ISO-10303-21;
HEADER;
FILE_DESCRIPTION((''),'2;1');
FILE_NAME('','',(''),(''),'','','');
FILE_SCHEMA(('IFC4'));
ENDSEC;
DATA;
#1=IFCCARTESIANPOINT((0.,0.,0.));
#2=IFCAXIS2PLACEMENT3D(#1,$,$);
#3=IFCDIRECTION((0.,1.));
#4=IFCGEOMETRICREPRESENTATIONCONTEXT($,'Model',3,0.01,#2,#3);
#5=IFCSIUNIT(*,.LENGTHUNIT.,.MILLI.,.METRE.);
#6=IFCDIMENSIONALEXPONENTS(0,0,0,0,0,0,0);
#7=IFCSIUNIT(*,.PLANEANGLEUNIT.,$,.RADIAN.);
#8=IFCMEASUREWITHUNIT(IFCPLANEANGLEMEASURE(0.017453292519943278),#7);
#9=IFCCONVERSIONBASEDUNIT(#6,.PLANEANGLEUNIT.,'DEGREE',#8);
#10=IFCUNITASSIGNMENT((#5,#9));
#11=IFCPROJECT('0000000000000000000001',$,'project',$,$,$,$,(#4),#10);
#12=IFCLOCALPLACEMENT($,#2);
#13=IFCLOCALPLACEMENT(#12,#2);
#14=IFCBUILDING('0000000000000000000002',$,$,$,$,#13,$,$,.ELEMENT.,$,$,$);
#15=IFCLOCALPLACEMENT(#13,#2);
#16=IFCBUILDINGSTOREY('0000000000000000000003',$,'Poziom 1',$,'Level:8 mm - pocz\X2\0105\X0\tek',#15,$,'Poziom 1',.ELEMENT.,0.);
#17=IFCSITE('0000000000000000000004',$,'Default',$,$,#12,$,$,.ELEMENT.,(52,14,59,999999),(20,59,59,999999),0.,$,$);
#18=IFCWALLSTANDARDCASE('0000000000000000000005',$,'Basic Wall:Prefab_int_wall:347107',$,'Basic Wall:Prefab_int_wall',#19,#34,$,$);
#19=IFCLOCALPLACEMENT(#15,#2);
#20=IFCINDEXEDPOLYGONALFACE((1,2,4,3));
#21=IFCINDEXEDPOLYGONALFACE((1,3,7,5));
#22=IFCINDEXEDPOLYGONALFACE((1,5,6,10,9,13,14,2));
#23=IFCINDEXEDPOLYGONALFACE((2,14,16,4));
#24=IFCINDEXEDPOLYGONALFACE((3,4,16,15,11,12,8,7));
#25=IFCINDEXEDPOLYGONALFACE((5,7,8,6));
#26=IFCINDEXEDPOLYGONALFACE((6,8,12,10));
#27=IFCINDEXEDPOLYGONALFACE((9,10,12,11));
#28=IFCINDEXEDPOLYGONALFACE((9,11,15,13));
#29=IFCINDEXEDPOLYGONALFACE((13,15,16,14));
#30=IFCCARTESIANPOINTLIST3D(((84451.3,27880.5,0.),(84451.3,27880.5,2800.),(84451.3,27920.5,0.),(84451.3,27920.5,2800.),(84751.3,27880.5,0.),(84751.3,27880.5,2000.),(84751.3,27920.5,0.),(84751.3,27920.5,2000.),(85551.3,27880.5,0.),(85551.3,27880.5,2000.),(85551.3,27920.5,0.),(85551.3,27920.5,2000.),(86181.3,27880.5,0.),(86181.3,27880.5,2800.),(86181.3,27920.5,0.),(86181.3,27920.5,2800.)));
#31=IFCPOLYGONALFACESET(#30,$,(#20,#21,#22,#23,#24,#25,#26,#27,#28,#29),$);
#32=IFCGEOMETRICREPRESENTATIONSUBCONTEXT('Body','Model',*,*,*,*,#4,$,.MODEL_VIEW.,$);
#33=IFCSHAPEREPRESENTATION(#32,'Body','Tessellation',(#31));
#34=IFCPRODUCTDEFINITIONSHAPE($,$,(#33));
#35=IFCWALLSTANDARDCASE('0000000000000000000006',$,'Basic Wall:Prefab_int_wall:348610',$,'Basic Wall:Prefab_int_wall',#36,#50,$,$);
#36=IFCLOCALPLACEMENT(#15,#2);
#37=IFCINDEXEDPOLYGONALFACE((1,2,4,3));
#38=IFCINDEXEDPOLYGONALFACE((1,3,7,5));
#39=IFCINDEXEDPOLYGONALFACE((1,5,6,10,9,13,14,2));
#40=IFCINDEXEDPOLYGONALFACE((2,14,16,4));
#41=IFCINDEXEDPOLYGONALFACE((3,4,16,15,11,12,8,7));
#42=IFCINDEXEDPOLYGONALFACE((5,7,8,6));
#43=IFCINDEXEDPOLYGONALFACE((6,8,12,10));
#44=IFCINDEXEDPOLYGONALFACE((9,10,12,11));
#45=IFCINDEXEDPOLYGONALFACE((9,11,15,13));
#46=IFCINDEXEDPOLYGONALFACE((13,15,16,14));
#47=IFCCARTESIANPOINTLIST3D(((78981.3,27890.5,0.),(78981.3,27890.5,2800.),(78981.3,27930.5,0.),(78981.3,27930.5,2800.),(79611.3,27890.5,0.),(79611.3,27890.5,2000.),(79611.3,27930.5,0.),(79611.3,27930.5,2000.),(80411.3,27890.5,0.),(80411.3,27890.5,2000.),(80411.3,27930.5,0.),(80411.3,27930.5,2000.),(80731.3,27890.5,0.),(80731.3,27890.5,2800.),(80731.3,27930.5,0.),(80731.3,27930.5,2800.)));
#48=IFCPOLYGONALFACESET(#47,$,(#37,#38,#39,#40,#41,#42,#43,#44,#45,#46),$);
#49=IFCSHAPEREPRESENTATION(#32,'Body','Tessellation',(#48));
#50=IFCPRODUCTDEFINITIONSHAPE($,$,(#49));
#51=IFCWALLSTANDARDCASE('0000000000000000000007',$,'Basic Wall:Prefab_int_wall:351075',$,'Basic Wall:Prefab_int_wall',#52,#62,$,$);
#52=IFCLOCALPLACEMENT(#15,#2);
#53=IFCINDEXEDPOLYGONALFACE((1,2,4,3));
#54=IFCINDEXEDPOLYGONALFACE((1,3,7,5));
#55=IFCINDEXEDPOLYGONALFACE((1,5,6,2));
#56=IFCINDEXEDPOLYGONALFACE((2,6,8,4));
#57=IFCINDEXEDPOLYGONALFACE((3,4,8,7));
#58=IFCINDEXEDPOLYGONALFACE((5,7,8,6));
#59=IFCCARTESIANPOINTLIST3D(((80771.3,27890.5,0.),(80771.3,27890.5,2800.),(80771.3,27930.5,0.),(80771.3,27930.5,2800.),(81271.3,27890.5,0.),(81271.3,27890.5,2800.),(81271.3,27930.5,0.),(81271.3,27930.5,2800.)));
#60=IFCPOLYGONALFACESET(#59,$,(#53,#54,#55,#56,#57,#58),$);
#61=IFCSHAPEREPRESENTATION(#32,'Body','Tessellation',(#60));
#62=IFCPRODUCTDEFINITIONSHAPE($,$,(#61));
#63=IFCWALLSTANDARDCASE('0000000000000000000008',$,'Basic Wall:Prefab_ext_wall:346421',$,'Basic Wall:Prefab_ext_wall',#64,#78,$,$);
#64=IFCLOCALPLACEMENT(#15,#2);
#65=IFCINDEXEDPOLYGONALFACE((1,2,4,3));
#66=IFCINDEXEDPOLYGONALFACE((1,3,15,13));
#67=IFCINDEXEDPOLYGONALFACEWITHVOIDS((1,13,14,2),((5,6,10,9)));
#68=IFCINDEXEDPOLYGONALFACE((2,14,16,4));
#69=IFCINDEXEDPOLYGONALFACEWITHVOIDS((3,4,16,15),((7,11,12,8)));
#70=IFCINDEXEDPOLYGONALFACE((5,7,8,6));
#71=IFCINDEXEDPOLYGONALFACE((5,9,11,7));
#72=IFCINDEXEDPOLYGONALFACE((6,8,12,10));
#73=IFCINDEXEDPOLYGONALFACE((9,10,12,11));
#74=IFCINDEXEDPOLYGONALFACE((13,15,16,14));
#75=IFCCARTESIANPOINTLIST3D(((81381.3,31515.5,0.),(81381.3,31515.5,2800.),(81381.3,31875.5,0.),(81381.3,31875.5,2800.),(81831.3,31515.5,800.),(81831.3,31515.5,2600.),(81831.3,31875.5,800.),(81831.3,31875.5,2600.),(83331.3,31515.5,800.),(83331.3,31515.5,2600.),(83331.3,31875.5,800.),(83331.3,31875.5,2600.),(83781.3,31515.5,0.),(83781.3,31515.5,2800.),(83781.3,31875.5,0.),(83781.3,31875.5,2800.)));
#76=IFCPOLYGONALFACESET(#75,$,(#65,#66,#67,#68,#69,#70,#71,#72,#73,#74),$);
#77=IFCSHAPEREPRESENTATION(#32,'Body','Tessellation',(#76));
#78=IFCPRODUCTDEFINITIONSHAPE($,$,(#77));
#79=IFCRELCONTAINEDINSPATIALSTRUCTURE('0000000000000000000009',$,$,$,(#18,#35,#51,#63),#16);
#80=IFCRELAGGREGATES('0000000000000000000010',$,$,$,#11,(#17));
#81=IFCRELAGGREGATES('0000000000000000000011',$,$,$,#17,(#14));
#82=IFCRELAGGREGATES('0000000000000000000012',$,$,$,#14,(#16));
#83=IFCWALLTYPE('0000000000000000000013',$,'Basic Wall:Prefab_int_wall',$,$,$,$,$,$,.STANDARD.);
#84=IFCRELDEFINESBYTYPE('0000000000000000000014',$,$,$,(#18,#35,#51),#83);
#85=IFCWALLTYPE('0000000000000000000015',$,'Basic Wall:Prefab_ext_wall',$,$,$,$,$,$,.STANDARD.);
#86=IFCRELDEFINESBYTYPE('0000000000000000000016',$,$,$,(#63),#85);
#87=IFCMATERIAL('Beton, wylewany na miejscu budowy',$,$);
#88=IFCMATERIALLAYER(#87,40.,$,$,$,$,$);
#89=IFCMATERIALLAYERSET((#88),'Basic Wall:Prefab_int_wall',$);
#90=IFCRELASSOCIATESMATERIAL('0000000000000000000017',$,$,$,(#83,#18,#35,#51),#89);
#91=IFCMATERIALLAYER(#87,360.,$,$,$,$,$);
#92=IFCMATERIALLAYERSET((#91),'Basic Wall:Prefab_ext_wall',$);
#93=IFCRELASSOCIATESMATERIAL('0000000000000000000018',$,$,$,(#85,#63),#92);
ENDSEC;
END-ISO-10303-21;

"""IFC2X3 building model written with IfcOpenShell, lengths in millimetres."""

from ifc_helpers import new_model, entity, si_unit, converted_unit, direction, frame, frame_2d, origin, origin_2d_with_axis, place, context, subcontext, project, spatial, rectangle, extrude, material, layer, layer_set, layer_usage, type_object, element, save


model = new_model("IFC2X3")

# Units and contexts
model_context = context("Model", 3, precision=0.01, world=origin(), true_north=direction((0.0, 1.0)))
body_context = subcontext(model_context, "Body", "Model", "MODEL_VIEW")
ifc_project = project(units=[si_unit("LENGTHUNIT", "METRE", prefix="MILLI"), converted_unit("PLANEANGLEUNIT", "DEGREE", entity("IfcPlaneAngleMeasure", 0.017453292519943278), si_unit("PLANEANGLEUNIT", "RADIAN"), dimensions=[0, 0, 0, 0, 0, 0, 0])], contexts=[model_context])

# Site, building, storey
site_placement = place(None, origin())
site = spatial("IfcSite", under=ifc_project, at=site_placement, Name="Default", CompositionType="ELEMENT", RefLatitude=(52, 14, 59, 999999), RefLongitude=(20, 59, 59, 999999), RefElevation=0.0)
building_placement = place(site_placement, origin())
building = spatial("IfcBuilding", under=site, at=building_placement, CompositionType="ELEMENT")
storey_placement = place(building_placement, origin())
storey = spatial("IfcBuildingStorey", under=building, at=storey_placement, Name="Poziom 1", ObjectType="Level:8 mm - początek", LongName="Poziom 1", CompositionType="ELEMENT", Elevation=0.0)

# Shared definitions
ifc_material = material(Name="Beton, wylewany na miejscu budowy")
ifc_layer_1 = layer(ifc_material, 40.0)
ifc_layer_set_1 = layer_set([ifc_layer_1], Name="Basic Wall:Prefab_int_wall")
wall_type_1 = type_object("IfcWallType", Name="Basic Wall:Prefab_int_wall", PredefinedType="STANDARD", material=ifc_layer_set_1)

# Walls, openings
ifc_layer_usage_1 = layer_usage(ifc_layer_set_1, "AXIS2", "NEGATIVE", 20.0)
wall_1_placement = place(storey_placement, frame((84451.3, 27900.5, 0.0)))
wall_1 = element("IfcWallStandardCase", 1, at=wall_1_placement, inside=storey, type_object=wall_type_1, material=ifc_layer_usage_1, Name="Basic Wall:Prefab_int_wall:347107", ObjectType="Basic Wall:Prefab_int_wall", context=body_context, shape_type="SweptSolid", body=[
    extrude(rectangle(XDim=1730.0, YDim=40.0, at=frame_2d((865.0, 0.0), x_axis=(-1.0, 0.0))), origin(), (0.0, 0.0, 1.0), 2800.0),
])
opening_1_placement = place(wall_1_placement, origin())
element("IfcOpeningElement", 2, at=opening_1_placement, cuts=wall_1, ObjectType="Opening", context=body_context, shape_type="SweptSolid", body=[
    extrude(rectangle(XDim=2000.0, YDim=800.0, at=frame_2d((0.0, 0.0), x_axis=(0.0, 1.0))), frame((700.0, 20.0, 1000.0), z_axis=(0.0, -1.0, 0.0), x_axis=(1.0, 0.0, 0.0)), (0.0, 0.0, 1.0), 40.0),
])
ifc_layer_usage_2 = layer_usage(ifc_layer_set_1, "AXIS2", "NEGATIVE", 20.0)
wall_2_placement = place(storey_placement, frame((78981.3, 27910.5, 0.0)))
wall_2 = element("IfcWallStandardCase", 3, at=wall_2_placement, inside=storey, type_object=wall_type_1, material=ifc_layer_usage_2, Name="Basic Wall:Prefab_int_wall:348610", ObjectType="Basic Wall:Prefab_int_wall", context=body_context, shape_type="SweptSolid", body=[
    extrude(rectangle(XDim=1750.0, YDim=40.0, at=frame_2d((875.0, 0.0), x_axis=(-1.0, 0.0))), origin(), (0.0, 0.0, 1.0), 2800.0),
])
opening_2_placement = place(wall_2_placement, origin())
element("IfcOpeningElement", 4, at=opening_2_placement, cuts=wall_2, ObjectType="Opening", context=body_context, shape_type="SweptSolid", body=[
    extrude(rectangle(XDim=2000.0, YDim=800.0, at=frame_2d((0.0, 0.0), x_axis=(0.0, 1.0))), frame((1030.0, 20.0, 1000.0), z_axis=(0.0, -1.0, 0.0), x_axis=(1.0, 0.0, 0.0)), (0.0, 0.0, 1.0), 40.0),
])

# Wall
ifc_layer_usage_3 = layer_usage(ifc_layer_set_1, "AXIS2", "NEGATIVE", 20.0)
wall_3_placement = place(storey_placement, frame((80771.3, 27910.5, 0.0)))
element("IfcWallStandardCase", 5, at=wall_3_placement, inside=storey, type_object=wall_type_1, material=ifc_layer_usage_3, Name="Basic Wall:Prefab_int_wall:351075", ObjectType="Basic Wall:Prefab_int_wall", context=body_context, shape_type="SweptSolid", body=[
    extrude(rectangle(XDim=500.0, YDim=40.0, at=frame_2d((250.0, 0.0), x_axis=(-1.0, 0.0))), origin(), (0.0, 0.0, 1.0), 2800.0),
])

# Wall, opening
ifc_layer_2 = layer(ifc_material, 360.0)
ifc_layer_set_2 = layer_set([ifc_layer_2], Name="Basic Wall:Prefab_ext_wall")
ifc_layer_usage_4 = layer_usage(ifc_layer_set_2, "AXIS2", "NEGATIVE", 180.0)
wall_type_2 = type_object("IfcWallType", Name="Basic Wall:Prefab_ext_wall", PredefinedType="STANDARD", material=ifc_layer_set_2)
wall_4_placement = place(storey_placement, frame((81381.3, 31695.5, 0.0)))
wall_4 = element("IfcWallStandardCase", 6, at=wall_4_placement, inside=storey, type_object=wall_type_2, material=ifc_layer_usage_4, Name="Basic Wall:Prefab_ext_wall:346421", ObjectType="Basic Wall:Prefab_ext_wall", context=body_context, shape_type="SweptSolid", body=[
    extrude(rectangle(XDim=2400.0, YDim=360.0, at=frame_2d((1200.0, 0.0), x_axis=(-1.0, 0.0))), origin(), (0.0, 0.0, 1.0), 2800.0),
])
opening_3_placement = place(wall_4_placement, origin())
element("IfcOpeningElement", 7, at=opening_3_placement, cuts=wall_4, ObjectType="Opening", context=body_context, shape_type="SweptSolid", body=[
    extrude(rectangle(XDim=1800.0, YDim=1500.0, at=origin_2d_with_axis()), frame((1200.0, 180.0, 1700.0), z_axis=(0.0, -1.0, 0.0), x_axis=(0.0, 0.0, 1.0)), (0.0, 0.0, 1.0), 360.0),
])

save(model, "model.ifc")
